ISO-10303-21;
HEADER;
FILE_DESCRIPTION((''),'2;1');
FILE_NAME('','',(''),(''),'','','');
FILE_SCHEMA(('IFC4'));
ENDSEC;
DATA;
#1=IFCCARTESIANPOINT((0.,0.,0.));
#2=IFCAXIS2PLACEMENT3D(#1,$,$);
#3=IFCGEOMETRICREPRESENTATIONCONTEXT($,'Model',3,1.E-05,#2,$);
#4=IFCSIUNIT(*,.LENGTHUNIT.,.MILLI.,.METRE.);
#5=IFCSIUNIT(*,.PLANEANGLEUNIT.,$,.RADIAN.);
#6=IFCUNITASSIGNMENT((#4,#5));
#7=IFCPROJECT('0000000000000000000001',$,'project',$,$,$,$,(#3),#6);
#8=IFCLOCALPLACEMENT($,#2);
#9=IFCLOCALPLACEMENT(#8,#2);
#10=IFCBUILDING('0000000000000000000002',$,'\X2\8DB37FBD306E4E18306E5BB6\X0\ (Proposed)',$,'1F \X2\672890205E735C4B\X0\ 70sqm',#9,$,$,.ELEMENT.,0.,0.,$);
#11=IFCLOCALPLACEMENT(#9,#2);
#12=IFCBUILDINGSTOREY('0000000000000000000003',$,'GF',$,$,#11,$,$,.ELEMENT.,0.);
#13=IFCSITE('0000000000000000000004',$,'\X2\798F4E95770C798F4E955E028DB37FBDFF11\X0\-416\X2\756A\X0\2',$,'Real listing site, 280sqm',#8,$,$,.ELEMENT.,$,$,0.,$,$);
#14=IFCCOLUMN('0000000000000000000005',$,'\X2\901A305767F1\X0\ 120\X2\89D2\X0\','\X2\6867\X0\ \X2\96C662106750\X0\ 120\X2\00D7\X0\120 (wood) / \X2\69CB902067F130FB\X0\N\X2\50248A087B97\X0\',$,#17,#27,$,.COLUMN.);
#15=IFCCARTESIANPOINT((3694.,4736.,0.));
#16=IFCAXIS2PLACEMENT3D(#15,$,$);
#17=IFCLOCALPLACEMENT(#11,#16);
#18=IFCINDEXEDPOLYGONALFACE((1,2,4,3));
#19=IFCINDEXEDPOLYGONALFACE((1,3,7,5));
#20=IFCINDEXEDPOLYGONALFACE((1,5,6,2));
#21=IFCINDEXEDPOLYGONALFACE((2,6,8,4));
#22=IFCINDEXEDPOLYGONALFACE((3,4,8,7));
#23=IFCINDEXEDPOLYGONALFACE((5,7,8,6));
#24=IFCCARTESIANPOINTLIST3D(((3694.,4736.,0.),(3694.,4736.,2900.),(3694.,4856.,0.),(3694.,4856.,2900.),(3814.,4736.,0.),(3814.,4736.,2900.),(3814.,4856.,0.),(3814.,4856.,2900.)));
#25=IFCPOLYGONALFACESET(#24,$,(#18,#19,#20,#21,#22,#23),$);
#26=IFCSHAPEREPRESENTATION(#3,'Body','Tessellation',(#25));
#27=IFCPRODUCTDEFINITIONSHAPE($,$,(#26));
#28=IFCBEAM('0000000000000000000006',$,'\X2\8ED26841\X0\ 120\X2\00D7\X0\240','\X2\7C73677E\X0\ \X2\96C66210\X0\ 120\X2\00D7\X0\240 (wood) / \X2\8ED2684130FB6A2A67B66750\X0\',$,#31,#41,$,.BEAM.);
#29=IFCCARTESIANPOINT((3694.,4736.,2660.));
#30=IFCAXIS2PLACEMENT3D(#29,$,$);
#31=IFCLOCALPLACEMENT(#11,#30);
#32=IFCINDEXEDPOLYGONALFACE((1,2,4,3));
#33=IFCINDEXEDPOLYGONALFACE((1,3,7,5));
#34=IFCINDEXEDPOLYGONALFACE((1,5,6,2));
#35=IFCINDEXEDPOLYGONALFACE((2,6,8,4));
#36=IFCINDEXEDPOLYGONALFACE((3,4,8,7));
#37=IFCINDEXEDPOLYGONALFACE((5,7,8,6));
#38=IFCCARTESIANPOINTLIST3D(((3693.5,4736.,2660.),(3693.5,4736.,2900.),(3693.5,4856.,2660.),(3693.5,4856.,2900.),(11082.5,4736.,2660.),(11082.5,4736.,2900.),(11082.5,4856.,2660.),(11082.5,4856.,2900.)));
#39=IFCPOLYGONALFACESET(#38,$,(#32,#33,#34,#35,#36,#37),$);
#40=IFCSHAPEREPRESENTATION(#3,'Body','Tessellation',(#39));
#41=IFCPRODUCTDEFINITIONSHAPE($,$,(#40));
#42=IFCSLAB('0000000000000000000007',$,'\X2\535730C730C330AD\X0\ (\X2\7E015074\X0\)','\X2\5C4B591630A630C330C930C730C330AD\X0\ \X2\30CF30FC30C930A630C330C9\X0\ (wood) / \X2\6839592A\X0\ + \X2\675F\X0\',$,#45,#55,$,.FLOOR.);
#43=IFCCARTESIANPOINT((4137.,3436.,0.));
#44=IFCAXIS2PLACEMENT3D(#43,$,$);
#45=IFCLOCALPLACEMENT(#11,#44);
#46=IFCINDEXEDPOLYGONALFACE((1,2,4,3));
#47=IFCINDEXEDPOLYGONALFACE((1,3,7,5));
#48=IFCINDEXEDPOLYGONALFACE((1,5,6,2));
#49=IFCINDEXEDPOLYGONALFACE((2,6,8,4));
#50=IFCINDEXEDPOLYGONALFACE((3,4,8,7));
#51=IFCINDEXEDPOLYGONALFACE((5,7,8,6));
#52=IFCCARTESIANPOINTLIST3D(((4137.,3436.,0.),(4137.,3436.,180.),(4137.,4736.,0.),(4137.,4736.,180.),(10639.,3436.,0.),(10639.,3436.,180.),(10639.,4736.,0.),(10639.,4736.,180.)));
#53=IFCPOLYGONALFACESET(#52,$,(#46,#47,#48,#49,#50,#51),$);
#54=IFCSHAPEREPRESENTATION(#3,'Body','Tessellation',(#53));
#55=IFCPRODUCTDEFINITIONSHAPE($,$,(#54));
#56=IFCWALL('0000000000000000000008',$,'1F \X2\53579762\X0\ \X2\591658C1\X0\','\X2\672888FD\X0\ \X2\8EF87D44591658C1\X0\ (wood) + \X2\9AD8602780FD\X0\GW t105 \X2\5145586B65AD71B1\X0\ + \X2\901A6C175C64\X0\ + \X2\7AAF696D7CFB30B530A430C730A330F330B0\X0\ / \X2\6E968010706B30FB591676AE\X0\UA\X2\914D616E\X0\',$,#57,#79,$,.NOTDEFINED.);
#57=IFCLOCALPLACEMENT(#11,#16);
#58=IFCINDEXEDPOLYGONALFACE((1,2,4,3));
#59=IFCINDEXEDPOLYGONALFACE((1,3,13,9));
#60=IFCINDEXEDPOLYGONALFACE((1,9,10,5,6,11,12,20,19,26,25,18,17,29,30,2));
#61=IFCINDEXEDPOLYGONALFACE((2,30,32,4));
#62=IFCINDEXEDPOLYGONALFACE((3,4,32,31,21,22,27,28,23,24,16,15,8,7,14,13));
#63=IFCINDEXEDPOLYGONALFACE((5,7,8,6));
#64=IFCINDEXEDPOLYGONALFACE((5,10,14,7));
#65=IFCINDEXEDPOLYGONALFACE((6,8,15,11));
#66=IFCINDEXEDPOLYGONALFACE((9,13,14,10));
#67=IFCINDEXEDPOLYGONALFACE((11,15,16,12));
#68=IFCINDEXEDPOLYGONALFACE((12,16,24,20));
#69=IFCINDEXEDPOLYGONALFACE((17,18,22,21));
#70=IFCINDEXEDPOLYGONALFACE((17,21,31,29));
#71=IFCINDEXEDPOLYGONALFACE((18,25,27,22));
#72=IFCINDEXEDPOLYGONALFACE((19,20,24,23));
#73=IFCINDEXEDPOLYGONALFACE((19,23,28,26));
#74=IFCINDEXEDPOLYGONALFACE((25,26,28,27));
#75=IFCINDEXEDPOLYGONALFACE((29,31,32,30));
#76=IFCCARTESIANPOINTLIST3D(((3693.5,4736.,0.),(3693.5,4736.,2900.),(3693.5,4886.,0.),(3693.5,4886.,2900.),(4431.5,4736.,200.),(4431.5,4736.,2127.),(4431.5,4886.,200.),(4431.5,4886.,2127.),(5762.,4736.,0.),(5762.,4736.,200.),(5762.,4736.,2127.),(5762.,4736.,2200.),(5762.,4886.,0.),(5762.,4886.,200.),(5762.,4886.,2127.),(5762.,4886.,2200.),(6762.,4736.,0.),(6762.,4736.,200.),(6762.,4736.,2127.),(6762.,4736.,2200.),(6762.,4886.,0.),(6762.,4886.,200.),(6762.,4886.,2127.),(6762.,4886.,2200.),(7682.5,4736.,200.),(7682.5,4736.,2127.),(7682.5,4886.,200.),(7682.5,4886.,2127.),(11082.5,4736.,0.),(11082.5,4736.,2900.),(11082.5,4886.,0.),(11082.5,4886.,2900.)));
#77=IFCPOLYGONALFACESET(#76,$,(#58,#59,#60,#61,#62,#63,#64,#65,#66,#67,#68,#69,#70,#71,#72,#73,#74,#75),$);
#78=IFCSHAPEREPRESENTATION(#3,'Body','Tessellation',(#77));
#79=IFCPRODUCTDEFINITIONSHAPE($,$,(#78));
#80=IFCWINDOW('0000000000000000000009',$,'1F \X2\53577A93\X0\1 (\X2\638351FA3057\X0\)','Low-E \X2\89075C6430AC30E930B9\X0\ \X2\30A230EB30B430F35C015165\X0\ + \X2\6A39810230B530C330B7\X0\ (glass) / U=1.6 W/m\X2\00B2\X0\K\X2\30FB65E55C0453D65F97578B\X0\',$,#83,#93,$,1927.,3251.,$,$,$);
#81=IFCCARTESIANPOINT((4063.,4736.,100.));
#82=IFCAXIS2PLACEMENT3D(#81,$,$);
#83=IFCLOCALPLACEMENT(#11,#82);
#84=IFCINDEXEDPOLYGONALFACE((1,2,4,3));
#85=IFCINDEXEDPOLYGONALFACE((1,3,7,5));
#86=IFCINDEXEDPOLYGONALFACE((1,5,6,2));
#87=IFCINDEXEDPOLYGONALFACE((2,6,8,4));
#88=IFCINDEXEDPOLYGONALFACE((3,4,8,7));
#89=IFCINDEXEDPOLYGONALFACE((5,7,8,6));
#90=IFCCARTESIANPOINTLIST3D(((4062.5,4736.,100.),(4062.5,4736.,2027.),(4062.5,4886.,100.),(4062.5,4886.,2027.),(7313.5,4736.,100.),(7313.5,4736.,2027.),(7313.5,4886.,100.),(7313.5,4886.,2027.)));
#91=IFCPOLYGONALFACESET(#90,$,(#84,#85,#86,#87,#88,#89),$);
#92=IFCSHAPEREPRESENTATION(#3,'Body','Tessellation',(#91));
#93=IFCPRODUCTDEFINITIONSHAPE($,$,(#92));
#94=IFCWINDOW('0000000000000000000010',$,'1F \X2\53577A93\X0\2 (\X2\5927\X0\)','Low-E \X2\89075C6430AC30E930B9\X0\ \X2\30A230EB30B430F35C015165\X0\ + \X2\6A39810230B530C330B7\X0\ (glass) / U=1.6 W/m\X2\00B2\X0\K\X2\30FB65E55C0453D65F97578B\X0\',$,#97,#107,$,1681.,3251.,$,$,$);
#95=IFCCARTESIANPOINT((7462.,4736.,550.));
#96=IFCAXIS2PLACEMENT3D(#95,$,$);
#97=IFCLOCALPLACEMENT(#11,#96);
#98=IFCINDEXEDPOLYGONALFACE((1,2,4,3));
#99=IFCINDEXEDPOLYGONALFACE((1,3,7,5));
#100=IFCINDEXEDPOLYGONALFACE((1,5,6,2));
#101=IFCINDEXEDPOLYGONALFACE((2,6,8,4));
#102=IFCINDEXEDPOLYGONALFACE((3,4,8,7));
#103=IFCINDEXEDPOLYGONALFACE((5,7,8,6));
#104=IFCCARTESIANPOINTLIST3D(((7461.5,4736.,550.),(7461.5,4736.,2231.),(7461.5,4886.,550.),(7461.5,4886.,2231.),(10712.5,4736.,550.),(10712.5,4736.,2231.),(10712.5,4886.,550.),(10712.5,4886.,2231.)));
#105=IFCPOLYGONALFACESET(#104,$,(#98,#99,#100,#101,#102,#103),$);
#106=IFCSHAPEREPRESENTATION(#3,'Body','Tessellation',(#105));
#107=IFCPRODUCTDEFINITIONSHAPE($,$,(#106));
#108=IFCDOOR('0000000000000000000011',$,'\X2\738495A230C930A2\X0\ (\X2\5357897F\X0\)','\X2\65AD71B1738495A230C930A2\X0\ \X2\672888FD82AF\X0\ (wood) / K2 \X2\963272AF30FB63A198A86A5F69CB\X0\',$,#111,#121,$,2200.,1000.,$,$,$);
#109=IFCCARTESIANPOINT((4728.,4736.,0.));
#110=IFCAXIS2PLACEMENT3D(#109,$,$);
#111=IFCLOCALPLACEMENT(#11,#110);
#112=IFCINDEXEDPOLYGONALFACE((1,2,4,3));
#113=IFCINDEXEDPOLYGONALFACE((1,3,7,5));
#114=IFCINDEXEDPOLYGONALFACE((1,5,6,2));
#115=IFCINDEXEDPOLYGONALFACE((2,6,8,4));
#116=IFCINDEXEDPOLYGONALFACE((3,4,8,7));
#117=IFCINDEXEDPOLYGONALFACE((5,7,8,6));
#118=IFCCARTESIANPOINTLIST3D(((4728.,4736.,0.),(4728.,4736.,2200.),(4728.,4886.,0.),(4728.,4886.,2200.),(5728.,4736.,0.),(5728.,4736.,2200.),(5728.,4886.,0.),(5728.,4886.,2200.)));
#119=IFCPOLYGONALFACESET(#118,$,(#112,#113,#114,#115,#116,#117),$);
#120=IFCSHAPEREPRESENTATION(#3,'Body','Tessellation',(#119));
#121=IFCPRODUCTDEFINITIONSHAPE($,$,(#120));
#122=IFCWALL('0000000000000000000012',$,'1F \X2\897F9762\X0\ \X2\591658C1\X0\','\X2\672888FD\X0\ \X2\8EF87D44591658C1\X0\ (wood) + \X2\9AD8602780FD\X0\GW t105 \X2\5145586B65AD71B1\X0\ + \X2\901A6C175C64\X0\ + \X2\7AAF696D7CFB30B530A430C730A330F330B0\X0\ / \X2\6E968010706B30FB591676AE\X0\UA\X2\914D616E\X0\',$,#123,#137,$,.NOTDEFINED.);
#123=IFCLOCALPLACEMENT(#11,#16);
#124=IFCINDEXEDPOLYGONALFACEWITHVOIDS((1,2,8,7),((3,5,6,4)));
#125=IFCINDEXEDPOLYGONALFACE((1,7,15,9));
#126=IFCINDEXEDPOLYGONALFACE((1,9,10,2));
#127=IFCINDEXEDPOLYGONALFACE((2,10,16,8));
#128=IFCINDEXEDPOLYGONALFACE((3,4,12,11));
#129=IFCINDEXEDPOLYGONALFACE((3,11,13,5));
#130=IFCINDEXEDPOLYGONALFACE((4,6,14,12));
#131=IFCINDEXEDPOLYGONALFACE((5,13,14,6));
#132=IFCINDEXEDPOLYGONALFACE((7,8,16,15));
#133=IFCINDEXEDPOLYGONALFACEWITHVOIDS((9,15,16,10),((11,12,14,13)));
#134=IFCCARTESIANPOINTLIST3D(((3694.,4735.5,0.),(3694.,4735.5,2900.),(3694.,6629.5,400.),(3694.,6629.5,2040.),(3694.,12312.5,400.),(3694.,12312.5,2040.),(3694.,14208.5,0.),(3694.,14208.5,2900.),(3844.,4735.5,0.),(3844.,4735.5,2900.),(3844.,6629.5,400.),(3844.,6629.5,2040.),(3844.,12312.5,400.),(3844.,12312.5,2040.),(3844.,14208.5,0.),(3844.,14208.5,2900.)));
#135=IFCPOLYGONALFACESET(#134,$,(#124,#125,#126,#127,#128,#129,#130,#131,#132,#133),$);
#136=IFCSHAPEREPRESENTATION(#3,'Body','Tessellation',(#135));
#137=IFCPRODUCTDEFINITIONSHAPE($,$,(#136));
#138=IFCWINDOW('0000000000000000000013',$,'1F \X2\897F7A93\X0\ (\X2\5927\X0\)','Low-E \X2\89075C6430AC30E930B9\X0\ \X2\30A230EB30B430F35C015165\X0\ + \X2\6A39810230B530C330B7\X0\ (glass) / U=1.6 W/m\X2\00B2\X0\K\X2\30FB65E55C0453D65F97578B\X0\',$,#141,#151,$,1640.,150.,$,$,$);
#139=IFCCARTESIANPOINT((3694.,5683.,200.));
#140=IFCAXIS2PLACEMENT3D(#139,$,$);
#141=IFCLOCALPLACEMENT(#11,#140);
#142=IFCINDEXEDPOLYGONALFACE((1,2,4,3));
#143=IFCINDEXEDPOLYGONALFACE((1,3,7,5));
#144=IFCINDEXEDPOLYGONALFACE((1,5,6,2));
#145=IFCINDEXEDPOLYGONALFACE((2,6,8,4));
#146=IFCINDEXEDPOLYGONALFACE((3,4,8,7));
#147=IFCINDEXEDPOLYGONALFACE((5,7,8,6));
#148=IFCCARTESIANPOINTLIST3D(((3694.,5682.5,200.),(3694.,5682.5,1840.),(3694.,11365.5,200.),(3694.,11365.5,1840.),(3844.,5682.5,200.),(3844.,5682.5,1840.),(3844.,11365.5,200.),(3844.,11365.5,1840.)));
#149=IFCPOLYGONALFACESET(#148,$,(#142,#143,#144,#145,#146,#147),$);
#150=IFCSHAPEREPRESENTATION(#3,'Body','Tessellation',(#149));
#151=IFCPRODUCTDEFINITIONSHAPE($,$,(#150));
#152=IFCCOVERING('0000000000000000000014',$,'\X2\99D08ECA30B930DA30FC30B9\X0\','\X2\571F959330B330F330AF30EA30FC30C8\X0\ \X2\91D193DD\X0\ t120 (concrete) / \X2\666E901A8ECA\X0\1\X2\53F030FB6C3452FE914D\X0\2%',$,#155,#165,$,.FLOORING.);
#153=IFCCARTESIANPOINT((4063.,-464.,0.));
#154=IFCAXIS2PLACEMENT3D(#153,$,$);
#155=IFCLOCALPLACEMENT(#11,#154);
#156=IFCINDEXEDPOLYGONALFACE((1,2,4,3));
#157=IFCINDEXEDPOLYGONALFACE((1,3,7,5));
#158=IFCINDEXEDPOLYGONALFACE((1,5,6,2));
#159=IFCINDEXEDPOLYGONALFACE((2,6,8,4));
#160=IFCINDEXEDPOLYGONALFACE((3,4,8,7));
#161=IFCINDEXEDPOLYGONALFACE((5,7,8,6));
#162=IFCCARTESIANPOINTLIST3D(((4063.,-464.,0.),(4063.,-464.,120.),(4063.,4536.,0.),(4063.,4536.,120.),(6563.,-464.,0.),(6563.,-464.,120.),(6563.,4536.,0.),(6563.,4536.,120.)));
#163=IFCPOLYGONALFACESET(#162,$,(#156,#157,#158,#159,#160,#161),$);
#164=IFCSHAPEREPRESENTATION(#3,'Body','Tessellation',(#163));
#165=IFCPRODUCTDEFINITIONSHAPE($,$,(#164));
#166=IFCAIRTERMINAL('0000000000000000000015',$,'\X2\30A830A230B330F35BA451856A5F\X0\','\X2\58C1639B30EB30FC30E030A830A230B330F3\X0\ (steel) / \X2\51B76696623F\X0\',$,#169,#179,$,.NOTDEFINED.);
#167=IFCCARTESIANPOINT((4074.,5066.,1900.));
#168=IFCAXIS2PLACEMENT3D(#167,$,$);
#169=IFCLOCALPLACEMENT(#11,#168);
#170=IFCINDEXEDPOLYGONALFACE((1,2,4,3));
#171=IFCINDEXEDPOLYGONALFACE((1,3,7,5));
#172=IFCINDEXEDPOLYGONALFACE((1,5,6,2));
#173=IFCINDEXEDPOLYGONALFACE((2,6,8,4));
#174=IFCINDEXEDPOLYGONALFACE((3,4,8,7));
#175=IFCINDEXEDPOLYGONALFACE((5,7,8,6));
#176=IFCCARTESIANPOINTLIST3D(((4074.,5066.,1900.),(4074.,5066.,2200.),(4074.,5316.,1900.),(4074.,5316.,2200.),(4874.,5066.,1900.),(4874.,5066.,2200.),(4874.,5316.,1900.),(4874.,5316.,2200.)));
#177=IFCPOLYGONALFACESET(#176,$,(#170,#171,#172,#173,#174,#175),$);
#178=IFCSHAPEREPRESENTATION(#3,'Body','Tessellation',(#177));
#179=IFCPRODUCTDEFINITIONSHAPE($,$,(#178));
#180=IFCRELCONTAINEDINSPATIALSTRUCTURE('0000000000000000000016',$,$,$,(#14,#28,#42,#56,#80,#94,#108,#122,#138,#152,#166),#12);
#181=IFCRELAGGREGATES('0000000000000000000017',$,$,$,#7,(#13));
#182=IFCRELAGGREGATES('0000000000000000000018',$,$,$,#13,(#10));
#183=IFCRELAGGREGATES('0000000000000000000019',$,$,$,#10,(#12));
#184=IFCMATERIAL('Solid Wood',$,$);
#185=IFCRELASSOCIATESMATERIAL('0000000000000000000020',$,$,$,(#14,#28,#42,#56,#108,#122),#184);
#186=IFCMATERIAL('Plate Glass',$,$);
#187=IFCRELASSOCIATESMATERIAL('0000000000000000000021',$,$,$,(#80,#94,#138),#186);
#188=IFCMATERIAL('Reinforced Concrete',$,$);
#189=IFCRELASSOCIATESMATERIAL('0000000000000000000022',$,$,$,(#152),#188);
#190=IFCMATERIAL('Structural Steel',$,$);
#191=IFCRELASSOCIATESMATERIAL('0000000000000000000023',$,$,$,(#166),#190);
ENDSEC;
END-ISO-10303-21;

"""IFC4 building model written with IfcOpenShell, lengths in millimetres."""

from ifc_helpers import new_model, si_unit, frame, frame_2d, origin, place, context, project, spatial, rectangle, extrude, material, element, fill, save


model = new_model("IFC4")

# Units and contexts
model_context = context("Model", 3, precision=1e-05, world=origin())
ifc_project = project(units=[si_unit("LENGTHUNIT", "METRE", prefix="MILLI"), si_unit("PLANEANGLEUNIT", "RADIAN")], contexts=[model_context])

# Site, building, storey
site_placement = place(None, origin())
site = spatial("IfcSite", under=ifc_project, at=site_placement, Name="福井県福井市足羽１-416番2", ObjectType="Real listing site, 280sqm", CompositionType="ELEMENT", RefElevation=0.0)
building_placement = place(site_placement, origin())
building = spatial("IfcBuilding", under=site, at=building_placement, Name="足羽の丘の家 (Proposed)", ObjectType="1F 木造平屋 70sqm", CompositionType="ELEMENT", ElevationOfRefHeight=0.0, ElevationOfTerrain=0.0)
storey_placement = place(building_placement, origin())
storey = spatial("IfcBuildingStorey", under=building, at=storey_placement, Name="GF", CompositionType="ELEMENT", Elevation=0.0)

# Column
ifc_material_1 = material(Name="Solid Wood")
column_1_placement = place(storey_placement, frame((3694.0, 4736.0, 0.0)))
element("IfcColumn", 1, at=column_1_placement, inside=storey, material=ifc_material_1, Name="通し柱 120角", Description="桧 集成材 120×120 (wood) / 構造柱・N値計算", PredefinedType="COLUMN", context=model_context, shape_type="SweptSolid", body=[
    extrude(rectangle(XDim=120.0, YDim=120.0, at=frame_2d((60.0, 60.0))), frame((3694.0, 4736.0, 0.0)), (0.0, 0.0, 1.0), 2900.0),
])

# Beam
beam_1_placement = place(storey_placement, frame((3694.0, 4736.0, 2660.0)))
element("IfcBeam", 2, at=beam_1_placement, inside=storey, material=ifc_material_1, Name="軒桁 120×240", Description="米松 集成 120×240 (wood) / 軒桁・横架材", PredefinedType="BEAM", context=model_context, shape_type="SweptSolid", body=[
    extrude(rectangle(XDim=7389.0, YDim=120.0, at=frame_2d((3694.0, 60.0))), frame((3694.0, 4736.0, 2660.0)), (0.0, 0.0, 1.0), 240.0),
])

# Slab
ifc_material_2 = material(Name="Reinforced Concrete")
slab_1_placement = place(storey_placement, frame((4137.0, 3436.0, 0.0)))
element("IfcSlab", 3, at=slab_1_placement, inside=storey, material=ifc_material_1, Name="南デッキ (縁側)", Description="屋外ウッドデッキ ハードウッド (wood) / 根太 + 束", PredefinedType="FLOOR", context=model_context, shape_type="SweptSolid", body=[
    extrude(rectangle(XDim=6502.0, YDim=1300.0, at=frame_2d((3251.0, 650.0))), frame((4137.0, 3436.0, 0.0)), (0.0, 0.0, 1.0), 180.0),
])

# Wall, openings, windows, door
wall_1_placement = place(storey_placement, frame((3694.0, 4736.0, 0.0)))
wall_1 = element("IfcWall", 4, at=wall_1_placement, inside=storey, material=ifc_material_1, Name="1F 南面 外壁", Description="木製 軸組外壁 (wood) + 高性能GW t105 充填断熱 + 通気層 + 窯業系サイディング / 準耐火・外皮UA配慮", PredefinedType="NOTDEFINED", context=model_context, shape_type="SweptSolid", body=[
    extrude(rectangle(XDim=7389.0, YDim=150.0, at=frame_2d((3694.0, 75.0))), frame((3694.0, 4736.0, 0.0)), (0.0, 0.0, 1.0), 2900.0),
])
opening_1_placement = place(storey_placement, frame((4063.0, 4736.0, 100.0)))
opening_1 = element("IfcOpeningElement", 5, at=opening_1_placement, cuts=wall_1, PredefinedType="NOTDEFINED", context=model_context, shape_type="SweptSolid", body=[
    extrude(rectangle(XDim=3251.0, YDim=150.0, at=frame_2d((1625.0, 75.0))), frame((4063.0, 4736.0, 100.0)), (0.0, 0.0, 1.0), 1927.0),
])
opening_2_placement = place(storey_placement, frame((7462.0, 4736.0, 550.0)))
opening_2 = element("IfcOpeningElement", 6, at=opening_2_placement, cuts=wall_1, PredefinedType="NOTDEFINED", context=model_context, shape_type="SweptSolid", body=[
    extrude(rectangle(XDim=3251.0, YDim=150.0, at=frame_2d((1625.0, 75.0))), frame((7462.0, 4736.0, 550.0)), (0.0, 0.0, 1.0), 1681.0),
])
opening_3_placement = place(storey_placement, frame((4728.0, 4736.0, 0.0)))
opening_3 = element("IfcOpeningElement", 7, at=opening_3_placement, cuts=wall_1, PredefinedType="NOTDEFINED", context=model_context, shape_type="SweptSolid", body=[
    extrude(rectangle(XDim=1000.0, YDim=150.0, at=frame_2d((500.0, 75.0))), frame((4728.0, 4736.0, 0.0)), (0.0, 0.0, 1.0), 2200.0),
])
ifc_material_3 = material(Name="Plate Glass")
window_1_placement = place(storey_placement, frame((4063.0, 4736.0, 100.0)))
window_1 = element("IfcWindow", 8, at=window_1_placement, inside=storey, material=ifc_material_3, Name="1F 南窓1 (掃出し)", Description="Low-E 複層ガラス アルゴン封入 + 樹脂サッシ (glass) / U=1.6 W/m²K・日射取得型", OverallHeight=1927.0, OverallWidth=3251.0, context=model_context, shape_type="SweptSolid", body=[
    extrude(rectangle(XDim=3251.0, YDim=150.0, at=frame_2d((1625.0, 75.0))), frame((4063.0, 4736.0, 100.0)), (0.0, 0.0, 1.0), 1927.0),
])
fill(opening_1, window_1)
window_2_placement = place(storey_placement, frame((7462.0, 4736.0, 550.0)))
window_2 = element("IfcWindow", 9, at=window_2_placement, inside=storey, material=ifc_material_3, Name="1F 南窓2 (大)", Description="Low-E 複層ガラス アルゴン封入 + 樹脂サッシ (glass) / U=1.6 W/m²K・日射取得型", OverallHeight=1681.0, OverallWidth=3251.0, context=model_context, shape_type="SweptSolid", body=[
    extrude(rectangle(XDim=3251.0, YDim=150.0, at=frame_2d((1625.0, 75.0))), frame((7462.0, 4736.0, 550.0)), (0.0, 0.0, 1.0), 1681.0),
])
fill(opening_2, window_2)
door_placement = place(storey_placement, frame((4728.0, 4736.0, 0.0)))
door = element("IfcDoor", 10, at=door_placement, inside=storey, material=ifc_material_1, Name="玄関ドア (南西)", Description="断熱玄関ドア 木製芯 (wood) / K2 防犯・採風機構", OverallHeight=2200.0, OverallWidth=1000.0, context=model_context, shape_type="SweptSolid", body=[
    extrude(rectangle(XDim=1000.0, YDim=150.0, at=frame_2d((500.0, 75.0))), frame((4728.0, 4736.0, 0.0)), (0.0, 0.0, 1.0), 2200.0),
])
fill(opening_3, door)

# Wall, opening, window
wall_2_placement = place(storey_placement, frame((3694.0, 4736.0, 0.0)))
wall_2 = element("IfcWall", 11, at=wall_2_placement, inside=storey, material=ifc_material_1, Name="1F 西面 外壁", Description="木製 軸組外壁 (wood) + 高性能GW t105 充填断熱 + 通気層 + 窯業系サイディング / 準耐火・外皮UA配慮", PredefinedType="NOTDEFINED", context=model_context, shape_type="SweptSolid", body=[
    extrude(rectangle(XDim=150.0, YDim=9473.0, at=frame_2d((75.0, 4736.0))), frame((3694.0, 4736.0, 0.0)), (0.0, 0.0, 1.0), 2900.0),
])
opening_4_placement = place(storey_placement, frame((3694.0, 5683.0, 200.0)))
opening_4 = element("IfcOpeningElement", 12, at=opening_4_placement, cuts=wall_2, PredefinedType="NOTDEFINED", context=model_context, shape_type="SweptSolid", body=[
    extrude(rectangle(XDim=150.0, YDim=5683.0, at=frame_2d((75.0, 2841.0))), frame((3694.0, 5683.0, 200.0)), (0.0, 0.0, 1.0), 1640.0),
])
window_3_placement = place(storey_placement, frame((3694.0, 5683.0, 200.0)))
window_3 = element("IfcWindow", 13, at=window_3_placement, inside=storey, material=ifc_material_3, Name="1F 西窓 (大)", Description="Low-E 複層ガラス アルゴン封入 + 樹脂サッシ (glass) / U=1.6 W/m²K・日射取得型", OverallHeight=1640.0, OverallWidth=150.0, context=model_context, shape_type="SweptSolid", body=[
    extrude(rectangle(XDim=150.0, YDim=5683.0, at=frame_2d((75.0, 2841.0))), frame((3694.0, 5683.0, 200.0)), (0.0, 0.0, 1.0), 1640.0),
])
fill(opening_4, window_3)

# Shared definitions
ifc_material_4 = material(Name="Structural Steel")

# Covering
covering_1_placement = place(storey_placement, frame((4063.0, -464.0, 0.0)))
element("IfcCovering", 14, at=covering_1_placement, inside=storey, material=ifc_material_2, Name="駐車スペース", Description="土間コンクリート 金鏝 t120 (concrete) / 普通車1台・水勾配2%", PredefinedType="FLOORING", context=model_context, shape_type="SweptSolid", body=[
    extrude(rectangle(XDim=2500.0, YDim=5000.0, at=frame_2d((1250.0, 2500.0))), frame((4063.0, -464.0, 0.0)), (0.0, 0.0, 1.0), 120.0),
])

# Air terminal
air_terminal_placement = place(storey_placement, frame((4074.0, 5066.0, 1900.0)))
element("IfcAirTerminal", 15, at=air_terminal_placement, inside=storey, material=ifc_material_4, Name="エアコン室内機", Description="壁掛ルームエアコン (steel) / 冷暖房", PredefinedType="NOTDEFINED", context=model_context, shape_type="SweptSolid", body=[
    extrude(rectangle(XDim=800.0, YDim=250.0, at=frame_2d((400.0, 125.0))), frame((4074.0, 5066.0, 1900.0)), (0.0, 0.0, 1.0), 300.0),
])

save(model, "model.ifc")
